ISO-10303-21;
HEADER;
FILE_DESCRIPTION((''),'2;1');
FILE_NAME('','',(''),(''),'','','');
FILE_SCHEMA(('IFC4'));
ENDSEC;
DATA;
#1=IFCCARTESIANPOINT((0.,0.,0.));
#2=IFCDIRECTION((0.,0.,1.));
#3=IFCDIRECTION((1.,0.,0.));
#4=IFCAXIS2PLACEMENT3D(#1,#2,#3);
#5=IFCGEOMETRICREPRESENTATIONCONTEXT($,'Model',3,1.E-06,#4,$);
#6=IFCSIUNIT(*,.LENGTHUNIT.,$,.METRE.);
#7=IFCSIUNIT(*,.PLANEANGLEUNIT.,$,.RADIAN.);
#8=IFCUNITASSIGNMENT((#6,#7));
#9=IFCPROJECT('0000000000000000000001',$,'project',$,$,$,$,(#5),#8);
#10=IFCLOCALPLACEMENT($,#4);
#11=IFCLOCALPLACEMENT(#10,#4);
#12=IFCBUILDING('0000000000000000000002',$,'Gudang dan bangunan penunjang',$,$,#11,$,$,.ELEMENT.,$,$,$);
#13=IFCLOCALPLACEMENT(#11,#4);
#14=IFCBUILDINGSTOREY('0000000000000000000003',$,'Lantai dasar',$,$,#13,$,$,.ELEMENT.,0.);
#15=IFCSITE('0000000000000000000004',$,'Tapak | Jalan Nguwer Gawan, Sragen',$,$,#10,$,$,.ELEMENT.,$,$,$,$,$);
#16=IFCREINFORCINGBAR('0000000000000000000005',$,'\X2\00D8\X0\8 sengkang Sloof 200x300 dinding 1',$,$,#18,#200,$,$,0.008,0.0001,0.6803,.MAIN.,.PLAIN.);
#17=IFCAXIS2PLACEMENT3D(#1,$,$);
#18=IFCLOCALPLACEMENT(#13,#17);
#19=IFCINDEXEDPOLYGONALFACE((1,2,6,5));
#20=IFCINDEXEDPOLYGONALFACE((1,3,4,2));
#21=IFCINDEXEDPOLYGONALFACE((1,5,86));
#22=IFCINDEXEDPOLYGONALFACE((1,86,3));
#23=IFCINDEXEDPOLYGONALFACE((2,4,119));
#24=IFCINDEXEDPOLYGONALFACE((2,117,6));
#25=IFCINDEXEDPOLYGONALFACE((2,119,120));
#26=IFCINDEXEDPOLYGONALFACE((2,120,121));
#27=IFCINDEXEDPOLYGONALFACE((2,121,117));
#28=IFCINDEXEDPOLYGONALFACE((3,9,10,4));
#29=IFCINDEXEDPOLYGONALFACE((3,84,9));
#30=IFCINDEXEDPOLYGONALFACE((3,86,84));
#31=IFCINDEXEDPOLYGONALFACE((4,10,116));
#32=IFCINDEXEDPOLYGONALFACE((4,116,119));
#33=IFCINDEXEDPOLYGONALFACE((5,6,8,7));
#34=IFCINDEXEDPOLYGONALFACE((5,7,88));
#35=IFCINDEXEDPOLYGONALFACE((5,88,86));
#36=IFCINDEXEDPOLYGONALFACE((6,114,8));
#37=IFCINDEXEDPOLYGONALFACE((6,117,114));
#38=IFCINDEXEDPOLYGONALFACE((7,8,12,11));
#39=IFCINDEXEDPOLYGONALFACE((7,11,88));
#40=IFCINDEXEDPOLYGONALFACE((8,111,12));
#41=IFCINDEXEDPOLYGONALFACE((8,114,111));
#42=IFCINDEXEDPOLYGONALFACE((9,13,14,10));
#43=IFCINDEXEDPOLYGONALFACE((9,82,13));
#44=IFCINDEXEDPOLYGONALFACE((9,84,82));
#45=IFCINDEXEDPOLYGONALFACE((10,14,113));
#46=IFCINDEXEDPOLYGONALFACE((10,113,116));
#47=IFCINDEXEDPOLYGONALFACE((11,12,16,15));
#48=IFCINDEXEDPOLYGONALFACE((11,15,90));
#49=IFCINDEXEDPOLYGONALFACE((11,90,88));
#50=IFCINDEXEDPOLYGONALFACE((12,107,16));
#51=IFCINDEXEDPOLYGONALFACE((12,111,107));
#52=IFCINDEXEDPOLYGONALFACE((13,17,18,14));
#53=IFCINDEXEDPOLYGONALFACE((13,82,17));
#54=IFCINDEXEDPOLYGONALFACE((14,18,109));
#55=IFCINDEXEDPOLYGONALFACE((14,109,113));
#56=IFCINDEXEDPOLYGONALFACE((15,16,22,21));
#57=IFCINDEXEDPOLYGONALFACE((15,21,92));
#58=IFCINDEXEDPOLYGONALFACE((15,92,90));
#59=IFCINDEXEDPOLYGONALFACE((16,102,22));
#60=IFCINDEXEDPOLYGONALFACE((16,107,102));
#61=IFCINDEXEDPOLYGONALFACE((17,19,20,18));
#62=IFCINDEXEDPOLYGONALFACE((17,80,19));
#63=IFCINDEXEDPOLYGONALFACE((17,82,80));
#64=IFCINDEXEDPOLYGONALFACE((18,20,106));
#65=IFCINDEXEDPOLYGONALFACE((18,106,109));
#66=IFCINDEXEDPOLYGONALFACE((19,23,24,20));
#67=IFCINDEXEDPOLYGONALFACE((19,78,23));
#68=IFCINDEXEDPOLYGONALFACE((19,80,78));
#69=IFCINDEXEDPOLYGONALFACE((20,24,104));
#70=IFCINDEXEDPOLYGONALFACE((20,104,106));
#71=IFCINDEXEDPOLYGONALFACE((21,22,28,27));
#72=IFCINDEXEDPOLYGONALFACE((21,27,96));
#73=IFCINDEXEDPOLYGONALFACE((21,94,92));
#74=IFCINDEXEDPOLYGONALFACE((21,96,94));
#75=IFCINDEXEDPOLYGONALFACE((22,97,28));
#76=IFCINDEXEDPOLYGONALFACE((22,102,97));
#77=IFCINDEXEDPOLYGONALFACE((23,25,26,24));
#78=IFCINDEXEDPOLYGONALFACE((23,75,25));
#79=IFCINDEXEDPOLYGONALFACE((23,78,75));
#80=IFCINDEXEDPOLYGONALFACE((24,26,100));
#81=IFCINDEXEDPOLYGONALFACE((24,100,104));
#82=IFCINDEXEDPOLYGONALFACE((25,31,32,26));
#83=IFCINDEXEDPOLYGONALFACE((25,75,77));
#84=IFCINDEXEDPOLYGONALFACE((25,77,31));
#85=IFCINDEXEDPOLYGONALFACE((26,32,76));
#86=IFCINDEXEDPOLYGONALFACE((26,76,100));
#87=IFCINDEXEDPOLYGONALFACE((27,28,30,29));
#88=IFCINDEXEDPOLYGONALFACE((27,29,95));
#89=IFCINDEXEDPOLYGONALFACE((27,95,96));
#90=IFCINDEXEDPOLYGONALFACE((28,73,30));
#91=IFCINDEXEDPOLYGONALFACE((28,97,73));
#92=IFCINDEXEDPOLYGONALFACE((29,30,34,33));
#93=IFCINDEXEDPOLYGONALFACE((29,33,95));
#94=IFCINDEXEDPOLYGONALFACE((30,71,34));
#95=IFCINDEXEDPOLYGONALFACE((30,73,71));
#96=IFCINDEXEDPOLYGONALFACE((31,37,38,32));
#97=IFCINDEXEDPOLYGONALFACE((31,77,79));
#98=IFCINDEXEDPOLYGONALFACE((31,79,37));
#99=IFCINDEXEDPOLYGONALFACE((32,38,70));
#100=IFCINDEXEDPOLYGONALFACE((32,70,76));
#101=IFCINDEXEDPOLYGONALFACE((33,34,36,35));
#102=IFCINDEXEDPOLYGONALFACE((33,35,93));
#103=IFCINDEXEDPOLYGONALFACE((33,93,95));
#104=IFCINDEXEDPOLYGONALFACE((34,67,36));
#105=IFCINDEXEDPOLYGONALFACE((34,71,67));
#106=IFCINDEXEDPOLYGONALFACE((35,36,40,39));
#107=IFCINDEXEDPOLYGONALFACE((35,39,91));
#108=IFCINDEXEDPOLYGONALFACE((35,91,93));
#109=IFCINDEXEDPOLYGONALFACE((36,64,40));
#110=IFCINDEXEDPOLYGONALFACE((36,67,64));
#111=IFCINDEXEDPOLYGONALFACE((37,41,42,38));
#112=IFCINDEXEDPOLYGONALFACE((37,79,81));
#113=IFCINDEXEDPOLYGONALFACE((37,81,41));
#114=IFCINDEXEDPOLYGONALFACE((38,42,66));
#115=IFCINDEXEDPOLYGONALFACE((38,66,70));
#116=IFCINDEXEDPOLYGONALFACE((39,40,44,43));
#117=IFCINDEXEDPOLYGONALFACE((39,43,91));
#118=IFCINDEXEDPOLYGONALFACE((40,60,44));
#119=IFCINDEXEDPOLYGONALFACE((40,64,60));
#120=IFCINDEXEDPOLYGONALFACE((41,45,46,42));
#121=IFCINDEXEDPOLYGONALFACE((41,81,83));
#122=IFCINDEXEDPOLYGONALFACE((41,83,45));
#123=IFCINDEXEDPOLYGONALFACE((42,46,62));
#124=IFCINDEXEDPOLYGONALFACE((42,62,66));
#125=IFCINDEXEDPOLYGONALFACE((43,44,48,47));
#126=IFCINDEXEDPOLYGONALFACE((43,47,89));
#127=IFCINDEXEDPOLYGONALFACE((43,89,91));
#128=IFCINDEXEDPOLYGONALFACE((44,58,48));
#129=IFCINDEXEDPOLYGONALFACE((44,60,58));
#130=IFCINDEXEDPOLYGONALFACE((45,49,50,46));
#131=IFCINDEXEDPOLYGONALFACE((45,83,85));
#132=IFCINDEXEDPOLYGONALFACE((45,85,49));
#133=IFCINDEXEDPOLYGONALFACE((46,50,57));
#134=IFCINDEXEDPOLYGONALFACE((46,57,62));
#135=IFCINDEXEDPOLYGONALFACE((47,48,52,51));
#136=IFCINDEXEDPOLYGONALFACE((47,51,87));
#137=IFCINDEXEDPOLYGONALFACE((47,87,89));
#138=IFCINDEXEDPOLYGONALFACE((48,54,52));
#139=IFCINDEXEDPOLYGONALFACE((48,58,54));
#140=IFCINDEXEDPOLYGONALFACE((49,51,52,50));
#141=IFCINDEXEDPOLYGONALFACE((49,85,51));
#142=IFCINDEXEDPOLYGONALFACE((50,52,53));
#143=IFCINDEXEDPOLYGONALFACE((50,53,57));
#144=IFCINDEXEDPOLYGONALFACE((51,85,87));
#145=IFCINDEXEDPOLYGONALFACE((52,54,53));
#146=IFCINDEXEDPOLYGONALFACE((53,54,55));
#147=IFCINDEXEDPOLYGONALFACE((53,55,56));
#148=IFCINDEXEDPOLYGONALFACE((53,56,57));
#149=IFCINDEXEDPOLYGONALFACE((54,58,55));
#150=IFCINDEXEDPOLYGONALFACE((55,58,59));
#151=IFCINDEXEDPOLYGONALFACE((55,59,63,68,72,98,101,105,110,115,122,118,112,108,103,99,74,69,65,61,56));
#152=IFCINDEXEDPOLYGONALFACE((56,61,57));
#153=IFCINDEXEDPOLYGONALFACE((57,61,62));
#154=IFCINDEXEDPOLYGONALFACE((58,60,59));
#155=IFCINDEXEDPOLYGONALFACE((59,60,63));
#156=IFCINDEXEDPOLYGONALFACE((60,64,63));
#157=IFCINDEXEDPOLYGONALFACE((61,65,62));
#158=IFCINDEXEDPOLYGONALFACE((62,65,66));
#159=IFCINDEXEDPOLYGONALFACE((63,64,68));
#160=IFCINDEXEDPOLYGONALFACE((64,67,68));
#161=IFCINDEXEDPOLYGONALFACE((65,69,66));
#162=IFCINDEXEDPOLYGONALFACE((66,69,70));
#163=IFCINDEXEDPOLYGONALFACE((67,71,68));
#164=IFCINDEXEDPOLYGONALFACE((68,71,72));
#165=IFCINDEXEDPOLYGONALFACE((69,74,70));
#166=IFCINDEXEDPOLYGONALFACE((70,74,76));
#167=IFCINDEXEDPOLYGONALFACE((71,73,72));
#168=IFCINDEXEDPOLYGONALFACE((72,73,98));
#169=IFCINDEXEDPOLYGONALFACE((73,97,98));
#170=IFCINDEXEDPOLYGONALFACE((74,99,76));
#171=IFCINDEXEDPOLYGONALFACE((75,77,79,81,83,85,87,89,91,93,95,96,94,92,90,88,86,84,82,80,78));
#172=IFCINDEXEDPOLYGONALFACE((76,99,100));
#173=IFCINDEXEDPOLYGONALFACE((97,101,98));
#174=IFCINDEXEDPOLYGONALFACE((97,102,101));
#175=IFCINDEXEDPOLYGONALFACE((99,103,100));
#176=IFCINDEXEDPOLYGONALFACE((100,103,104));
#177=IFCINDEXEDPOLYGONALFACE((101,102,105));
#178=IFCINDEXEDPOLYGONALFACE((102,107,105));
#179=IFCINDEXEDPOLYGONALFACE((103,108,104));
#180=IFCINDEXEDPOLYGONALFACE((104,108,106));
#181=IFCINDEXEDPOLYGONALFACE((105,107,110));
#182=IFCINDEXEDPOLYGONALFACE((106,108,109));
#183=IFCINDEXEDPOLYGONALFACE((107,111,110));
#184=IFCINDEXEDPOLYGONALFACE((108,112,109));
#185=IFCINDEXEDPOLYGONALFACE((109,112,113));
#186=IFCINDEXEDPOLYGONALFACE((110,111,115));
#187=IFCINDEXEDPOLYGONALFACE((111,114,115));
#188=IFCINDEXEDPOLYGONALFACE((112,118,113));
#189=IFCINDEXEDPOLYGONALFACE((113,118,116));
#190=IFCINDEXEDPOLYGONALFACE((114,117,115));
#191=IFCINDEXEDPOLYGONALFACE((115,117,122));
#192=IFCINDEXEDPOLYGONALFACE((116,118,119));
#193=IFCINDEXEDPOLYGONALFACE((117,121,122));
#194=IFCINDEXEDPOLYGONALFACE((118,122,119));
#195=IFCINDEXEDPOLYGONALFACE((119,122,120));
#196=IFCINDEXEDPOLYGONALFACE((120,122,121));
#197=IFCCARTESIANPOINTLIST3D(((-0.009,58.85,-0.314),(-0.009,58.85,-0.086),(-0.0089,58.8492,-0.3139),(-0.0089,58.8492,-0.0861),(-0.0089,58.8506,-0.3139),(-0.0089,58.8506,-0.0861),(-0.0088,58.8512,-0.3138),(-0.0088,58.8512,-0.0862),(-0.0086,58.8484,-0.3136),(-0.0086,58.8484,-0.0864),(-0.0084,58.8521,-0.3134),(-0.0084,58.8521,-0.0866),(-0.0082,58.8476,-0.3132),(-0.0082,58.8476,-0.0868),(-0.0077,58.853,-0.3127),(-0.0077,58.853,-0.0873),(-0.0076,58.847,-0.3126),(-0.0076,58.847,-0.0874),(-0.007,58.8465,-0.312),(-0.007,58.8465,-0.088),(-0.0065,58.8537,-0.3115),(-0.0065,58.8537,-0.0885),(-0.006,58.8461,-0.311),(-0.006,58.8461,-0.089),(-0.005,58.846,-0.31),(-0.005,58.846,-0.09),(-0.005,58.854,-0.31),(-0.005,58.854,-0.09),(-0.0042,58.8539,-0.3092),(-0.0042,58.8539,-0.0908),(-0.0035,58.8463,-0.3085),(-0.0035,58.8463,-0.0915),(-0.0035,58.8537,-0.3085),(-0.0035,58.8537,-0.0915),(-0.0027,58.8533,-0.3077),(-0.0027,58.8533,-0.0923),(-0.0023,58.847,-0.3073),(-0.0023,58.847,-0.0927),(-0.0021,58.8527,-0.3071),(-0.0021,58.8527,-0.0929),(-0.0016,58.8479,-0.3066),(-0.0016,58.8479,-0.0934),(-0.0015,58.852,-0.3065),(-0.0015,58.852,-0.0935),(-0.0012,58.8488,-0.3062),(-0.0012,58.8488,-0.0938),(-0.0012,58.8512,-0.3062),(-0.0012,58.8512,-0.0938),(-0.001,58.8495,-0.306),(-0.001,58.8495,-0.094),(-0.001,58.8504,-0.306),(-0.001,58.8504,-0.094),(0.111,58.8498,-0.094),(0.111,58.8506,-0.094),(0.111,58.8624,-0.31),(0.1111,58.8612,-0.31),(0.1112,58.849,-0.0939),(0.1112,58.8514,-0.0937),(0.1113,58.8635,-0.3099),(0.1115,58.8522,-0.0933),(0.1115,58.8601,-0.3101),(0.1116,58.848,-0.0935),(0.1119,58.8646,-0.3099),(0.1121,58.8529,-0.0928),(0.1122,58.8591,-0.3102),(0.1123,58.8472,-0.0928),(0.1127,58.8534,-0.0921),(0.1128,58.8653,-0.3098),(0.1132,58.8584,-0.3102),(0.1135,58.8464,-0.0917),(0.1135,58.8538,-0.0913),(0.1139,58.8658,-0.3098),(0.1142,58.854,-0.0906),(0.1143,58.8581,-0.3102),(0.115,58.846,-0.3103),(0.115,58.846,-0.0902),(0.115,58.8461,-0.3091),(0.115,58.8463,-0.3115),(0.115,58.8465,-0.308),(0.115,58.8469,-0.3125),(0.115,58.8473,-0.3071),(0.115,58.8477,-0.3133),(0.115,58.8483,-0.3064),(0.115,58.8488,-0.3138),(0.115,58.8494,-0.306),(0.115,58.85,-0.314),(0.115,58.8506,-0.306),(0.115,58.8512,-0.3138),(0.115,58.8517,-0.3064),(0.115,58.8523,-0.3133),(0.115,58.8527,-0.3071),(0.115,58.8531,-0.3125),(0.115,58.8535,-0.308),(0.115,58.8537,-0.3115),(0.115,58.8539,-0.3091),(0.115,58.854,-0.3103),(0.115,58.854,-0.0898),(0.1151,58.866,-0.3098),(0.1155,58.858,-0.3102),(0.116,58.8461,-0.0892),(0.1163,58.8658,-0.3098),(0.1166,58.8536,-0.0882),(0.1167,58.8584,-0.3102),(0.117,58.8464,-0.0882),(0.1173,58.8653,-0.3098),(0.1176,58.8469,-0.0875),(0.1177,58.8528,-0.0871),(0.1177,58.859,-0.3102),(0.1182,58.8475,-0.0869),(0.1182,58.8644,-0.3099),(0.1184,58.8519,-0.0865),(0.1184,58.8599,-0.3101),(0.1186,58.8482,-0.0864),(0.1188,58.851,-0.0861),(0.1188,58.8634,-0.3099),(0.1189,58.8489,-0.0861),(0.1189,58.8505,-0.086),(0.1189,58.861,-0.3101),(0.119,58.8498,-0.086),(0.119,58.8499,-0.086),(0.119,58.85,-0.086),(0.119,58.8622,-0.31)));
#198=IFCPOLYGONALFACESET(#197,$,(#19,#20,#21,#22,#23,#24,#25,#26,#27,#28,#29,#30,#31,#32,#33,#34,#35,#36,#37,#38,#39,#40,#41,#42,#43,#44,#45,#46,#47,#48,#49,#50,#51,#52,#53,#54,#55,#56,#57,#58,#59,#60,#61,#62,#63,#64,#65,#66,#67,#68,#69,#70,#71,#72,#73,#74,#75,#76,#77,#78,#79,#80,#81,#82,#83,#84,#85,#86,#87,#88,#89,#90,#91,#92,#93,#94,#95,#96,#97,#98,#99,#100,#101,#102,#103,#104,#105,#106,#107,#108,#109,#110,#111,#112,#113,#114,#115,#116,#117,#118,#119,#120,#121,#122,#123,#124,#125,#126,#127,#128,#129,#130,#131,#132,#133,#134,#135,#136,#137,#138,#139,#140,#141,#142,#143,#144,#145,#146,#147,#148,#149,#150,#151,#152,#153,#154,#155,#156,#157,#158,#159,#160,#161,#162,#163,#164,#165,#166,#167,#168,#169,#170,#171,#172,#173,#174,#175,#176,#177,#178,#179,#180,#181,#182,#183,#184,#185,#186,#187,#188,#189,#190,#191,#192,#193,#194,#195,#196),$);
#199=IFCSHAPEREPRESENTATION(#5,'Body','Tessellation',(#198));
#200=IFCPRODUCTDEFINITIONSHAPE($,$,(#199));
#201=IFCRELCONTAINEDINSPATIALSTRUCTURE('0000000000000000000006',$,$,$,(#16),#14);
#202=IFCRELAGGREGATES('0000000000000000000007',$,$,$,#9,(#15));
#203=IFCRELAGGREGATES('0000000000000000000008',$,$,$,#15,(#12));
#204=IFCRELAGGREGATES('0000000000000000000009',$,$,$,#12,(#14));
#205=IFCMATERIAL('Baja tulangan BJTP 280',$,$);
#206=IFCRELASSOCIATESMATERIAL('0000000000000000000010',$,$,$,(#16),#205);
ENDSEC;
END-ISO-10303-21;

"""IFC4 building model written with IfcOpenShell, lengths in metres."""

from ifc_helpers import new_model, entity, si_unit, origin_with_axes, place, context, project, spatial, material, element, save


model = new_model("IFC4")

# Units and contexts
model_context = context("Model", 3, precision=1e-06, world=origin_with_axes())
ifc_project = project(units=[si_unit("LENGTHUNIT", "METRE"), si_unit("PLANEANGLEUNIT", "RADIAN")], contexts=[model_context])

# Site, building, storey
site_placement = place(None, origin_with_axes())
site = spatial("IfcSite", under=ifc_project, at=site_placement, Name="Tapak | Jalan Nguwer Gawan, Sragen", CompositionType="ELEMENT")
building_placement = place(site_placement, origin_with_axes())
building = spatial("IfcBuilding", under=site, at=building_placement, Name="Gudang dan bangunan penunjang", CompositionType="ELEMENT")
storey_placement = place(building_placement, origin_with_axes())
storey = spatial("IfcBuildingStorey", under=building, at=storey_placement, Name="Lantai dasar", CompositionType="ELEMENT", Elevation=0.0)

# Shared definitions
placement = place(None, origin_with_axes())

# Reinforcing bar
ifc_material_1 = material(Name="Baja tulangan BJTP 280")
element("IfcReinforcingBar", 1, at=placement, inside=storey, material=ifc_material_1, Name="Ø8 sengkang Sloof 200x300 dinding 1", BarLength=0.6803, BarSurface="PLAIN", CrossSectionArea=0.0001, NominalDiameter=0.008, PredefinedType="MAIN", context=model_context, shape_type="AdvancedSweptSolid", body=[
    entity("IfcSweptDiskSolid", entity("IfcPolyline", [entity("IfcCartesianPoint", [0.115, 58.85, -0.31]), entity("IfcCartesianPoint", [-0.005, 58.85, -0.31]), entity("IfcCartesianPoint", [-0.005, 58.85, -0.09]), entity("IfcCartesianPoint", [0.115, 58.85, -0.09]), entity("IfcCartesianPoint", [0.115, 58.862, -0.31])]), 0.004),
])

save(model, "model.ifc")
